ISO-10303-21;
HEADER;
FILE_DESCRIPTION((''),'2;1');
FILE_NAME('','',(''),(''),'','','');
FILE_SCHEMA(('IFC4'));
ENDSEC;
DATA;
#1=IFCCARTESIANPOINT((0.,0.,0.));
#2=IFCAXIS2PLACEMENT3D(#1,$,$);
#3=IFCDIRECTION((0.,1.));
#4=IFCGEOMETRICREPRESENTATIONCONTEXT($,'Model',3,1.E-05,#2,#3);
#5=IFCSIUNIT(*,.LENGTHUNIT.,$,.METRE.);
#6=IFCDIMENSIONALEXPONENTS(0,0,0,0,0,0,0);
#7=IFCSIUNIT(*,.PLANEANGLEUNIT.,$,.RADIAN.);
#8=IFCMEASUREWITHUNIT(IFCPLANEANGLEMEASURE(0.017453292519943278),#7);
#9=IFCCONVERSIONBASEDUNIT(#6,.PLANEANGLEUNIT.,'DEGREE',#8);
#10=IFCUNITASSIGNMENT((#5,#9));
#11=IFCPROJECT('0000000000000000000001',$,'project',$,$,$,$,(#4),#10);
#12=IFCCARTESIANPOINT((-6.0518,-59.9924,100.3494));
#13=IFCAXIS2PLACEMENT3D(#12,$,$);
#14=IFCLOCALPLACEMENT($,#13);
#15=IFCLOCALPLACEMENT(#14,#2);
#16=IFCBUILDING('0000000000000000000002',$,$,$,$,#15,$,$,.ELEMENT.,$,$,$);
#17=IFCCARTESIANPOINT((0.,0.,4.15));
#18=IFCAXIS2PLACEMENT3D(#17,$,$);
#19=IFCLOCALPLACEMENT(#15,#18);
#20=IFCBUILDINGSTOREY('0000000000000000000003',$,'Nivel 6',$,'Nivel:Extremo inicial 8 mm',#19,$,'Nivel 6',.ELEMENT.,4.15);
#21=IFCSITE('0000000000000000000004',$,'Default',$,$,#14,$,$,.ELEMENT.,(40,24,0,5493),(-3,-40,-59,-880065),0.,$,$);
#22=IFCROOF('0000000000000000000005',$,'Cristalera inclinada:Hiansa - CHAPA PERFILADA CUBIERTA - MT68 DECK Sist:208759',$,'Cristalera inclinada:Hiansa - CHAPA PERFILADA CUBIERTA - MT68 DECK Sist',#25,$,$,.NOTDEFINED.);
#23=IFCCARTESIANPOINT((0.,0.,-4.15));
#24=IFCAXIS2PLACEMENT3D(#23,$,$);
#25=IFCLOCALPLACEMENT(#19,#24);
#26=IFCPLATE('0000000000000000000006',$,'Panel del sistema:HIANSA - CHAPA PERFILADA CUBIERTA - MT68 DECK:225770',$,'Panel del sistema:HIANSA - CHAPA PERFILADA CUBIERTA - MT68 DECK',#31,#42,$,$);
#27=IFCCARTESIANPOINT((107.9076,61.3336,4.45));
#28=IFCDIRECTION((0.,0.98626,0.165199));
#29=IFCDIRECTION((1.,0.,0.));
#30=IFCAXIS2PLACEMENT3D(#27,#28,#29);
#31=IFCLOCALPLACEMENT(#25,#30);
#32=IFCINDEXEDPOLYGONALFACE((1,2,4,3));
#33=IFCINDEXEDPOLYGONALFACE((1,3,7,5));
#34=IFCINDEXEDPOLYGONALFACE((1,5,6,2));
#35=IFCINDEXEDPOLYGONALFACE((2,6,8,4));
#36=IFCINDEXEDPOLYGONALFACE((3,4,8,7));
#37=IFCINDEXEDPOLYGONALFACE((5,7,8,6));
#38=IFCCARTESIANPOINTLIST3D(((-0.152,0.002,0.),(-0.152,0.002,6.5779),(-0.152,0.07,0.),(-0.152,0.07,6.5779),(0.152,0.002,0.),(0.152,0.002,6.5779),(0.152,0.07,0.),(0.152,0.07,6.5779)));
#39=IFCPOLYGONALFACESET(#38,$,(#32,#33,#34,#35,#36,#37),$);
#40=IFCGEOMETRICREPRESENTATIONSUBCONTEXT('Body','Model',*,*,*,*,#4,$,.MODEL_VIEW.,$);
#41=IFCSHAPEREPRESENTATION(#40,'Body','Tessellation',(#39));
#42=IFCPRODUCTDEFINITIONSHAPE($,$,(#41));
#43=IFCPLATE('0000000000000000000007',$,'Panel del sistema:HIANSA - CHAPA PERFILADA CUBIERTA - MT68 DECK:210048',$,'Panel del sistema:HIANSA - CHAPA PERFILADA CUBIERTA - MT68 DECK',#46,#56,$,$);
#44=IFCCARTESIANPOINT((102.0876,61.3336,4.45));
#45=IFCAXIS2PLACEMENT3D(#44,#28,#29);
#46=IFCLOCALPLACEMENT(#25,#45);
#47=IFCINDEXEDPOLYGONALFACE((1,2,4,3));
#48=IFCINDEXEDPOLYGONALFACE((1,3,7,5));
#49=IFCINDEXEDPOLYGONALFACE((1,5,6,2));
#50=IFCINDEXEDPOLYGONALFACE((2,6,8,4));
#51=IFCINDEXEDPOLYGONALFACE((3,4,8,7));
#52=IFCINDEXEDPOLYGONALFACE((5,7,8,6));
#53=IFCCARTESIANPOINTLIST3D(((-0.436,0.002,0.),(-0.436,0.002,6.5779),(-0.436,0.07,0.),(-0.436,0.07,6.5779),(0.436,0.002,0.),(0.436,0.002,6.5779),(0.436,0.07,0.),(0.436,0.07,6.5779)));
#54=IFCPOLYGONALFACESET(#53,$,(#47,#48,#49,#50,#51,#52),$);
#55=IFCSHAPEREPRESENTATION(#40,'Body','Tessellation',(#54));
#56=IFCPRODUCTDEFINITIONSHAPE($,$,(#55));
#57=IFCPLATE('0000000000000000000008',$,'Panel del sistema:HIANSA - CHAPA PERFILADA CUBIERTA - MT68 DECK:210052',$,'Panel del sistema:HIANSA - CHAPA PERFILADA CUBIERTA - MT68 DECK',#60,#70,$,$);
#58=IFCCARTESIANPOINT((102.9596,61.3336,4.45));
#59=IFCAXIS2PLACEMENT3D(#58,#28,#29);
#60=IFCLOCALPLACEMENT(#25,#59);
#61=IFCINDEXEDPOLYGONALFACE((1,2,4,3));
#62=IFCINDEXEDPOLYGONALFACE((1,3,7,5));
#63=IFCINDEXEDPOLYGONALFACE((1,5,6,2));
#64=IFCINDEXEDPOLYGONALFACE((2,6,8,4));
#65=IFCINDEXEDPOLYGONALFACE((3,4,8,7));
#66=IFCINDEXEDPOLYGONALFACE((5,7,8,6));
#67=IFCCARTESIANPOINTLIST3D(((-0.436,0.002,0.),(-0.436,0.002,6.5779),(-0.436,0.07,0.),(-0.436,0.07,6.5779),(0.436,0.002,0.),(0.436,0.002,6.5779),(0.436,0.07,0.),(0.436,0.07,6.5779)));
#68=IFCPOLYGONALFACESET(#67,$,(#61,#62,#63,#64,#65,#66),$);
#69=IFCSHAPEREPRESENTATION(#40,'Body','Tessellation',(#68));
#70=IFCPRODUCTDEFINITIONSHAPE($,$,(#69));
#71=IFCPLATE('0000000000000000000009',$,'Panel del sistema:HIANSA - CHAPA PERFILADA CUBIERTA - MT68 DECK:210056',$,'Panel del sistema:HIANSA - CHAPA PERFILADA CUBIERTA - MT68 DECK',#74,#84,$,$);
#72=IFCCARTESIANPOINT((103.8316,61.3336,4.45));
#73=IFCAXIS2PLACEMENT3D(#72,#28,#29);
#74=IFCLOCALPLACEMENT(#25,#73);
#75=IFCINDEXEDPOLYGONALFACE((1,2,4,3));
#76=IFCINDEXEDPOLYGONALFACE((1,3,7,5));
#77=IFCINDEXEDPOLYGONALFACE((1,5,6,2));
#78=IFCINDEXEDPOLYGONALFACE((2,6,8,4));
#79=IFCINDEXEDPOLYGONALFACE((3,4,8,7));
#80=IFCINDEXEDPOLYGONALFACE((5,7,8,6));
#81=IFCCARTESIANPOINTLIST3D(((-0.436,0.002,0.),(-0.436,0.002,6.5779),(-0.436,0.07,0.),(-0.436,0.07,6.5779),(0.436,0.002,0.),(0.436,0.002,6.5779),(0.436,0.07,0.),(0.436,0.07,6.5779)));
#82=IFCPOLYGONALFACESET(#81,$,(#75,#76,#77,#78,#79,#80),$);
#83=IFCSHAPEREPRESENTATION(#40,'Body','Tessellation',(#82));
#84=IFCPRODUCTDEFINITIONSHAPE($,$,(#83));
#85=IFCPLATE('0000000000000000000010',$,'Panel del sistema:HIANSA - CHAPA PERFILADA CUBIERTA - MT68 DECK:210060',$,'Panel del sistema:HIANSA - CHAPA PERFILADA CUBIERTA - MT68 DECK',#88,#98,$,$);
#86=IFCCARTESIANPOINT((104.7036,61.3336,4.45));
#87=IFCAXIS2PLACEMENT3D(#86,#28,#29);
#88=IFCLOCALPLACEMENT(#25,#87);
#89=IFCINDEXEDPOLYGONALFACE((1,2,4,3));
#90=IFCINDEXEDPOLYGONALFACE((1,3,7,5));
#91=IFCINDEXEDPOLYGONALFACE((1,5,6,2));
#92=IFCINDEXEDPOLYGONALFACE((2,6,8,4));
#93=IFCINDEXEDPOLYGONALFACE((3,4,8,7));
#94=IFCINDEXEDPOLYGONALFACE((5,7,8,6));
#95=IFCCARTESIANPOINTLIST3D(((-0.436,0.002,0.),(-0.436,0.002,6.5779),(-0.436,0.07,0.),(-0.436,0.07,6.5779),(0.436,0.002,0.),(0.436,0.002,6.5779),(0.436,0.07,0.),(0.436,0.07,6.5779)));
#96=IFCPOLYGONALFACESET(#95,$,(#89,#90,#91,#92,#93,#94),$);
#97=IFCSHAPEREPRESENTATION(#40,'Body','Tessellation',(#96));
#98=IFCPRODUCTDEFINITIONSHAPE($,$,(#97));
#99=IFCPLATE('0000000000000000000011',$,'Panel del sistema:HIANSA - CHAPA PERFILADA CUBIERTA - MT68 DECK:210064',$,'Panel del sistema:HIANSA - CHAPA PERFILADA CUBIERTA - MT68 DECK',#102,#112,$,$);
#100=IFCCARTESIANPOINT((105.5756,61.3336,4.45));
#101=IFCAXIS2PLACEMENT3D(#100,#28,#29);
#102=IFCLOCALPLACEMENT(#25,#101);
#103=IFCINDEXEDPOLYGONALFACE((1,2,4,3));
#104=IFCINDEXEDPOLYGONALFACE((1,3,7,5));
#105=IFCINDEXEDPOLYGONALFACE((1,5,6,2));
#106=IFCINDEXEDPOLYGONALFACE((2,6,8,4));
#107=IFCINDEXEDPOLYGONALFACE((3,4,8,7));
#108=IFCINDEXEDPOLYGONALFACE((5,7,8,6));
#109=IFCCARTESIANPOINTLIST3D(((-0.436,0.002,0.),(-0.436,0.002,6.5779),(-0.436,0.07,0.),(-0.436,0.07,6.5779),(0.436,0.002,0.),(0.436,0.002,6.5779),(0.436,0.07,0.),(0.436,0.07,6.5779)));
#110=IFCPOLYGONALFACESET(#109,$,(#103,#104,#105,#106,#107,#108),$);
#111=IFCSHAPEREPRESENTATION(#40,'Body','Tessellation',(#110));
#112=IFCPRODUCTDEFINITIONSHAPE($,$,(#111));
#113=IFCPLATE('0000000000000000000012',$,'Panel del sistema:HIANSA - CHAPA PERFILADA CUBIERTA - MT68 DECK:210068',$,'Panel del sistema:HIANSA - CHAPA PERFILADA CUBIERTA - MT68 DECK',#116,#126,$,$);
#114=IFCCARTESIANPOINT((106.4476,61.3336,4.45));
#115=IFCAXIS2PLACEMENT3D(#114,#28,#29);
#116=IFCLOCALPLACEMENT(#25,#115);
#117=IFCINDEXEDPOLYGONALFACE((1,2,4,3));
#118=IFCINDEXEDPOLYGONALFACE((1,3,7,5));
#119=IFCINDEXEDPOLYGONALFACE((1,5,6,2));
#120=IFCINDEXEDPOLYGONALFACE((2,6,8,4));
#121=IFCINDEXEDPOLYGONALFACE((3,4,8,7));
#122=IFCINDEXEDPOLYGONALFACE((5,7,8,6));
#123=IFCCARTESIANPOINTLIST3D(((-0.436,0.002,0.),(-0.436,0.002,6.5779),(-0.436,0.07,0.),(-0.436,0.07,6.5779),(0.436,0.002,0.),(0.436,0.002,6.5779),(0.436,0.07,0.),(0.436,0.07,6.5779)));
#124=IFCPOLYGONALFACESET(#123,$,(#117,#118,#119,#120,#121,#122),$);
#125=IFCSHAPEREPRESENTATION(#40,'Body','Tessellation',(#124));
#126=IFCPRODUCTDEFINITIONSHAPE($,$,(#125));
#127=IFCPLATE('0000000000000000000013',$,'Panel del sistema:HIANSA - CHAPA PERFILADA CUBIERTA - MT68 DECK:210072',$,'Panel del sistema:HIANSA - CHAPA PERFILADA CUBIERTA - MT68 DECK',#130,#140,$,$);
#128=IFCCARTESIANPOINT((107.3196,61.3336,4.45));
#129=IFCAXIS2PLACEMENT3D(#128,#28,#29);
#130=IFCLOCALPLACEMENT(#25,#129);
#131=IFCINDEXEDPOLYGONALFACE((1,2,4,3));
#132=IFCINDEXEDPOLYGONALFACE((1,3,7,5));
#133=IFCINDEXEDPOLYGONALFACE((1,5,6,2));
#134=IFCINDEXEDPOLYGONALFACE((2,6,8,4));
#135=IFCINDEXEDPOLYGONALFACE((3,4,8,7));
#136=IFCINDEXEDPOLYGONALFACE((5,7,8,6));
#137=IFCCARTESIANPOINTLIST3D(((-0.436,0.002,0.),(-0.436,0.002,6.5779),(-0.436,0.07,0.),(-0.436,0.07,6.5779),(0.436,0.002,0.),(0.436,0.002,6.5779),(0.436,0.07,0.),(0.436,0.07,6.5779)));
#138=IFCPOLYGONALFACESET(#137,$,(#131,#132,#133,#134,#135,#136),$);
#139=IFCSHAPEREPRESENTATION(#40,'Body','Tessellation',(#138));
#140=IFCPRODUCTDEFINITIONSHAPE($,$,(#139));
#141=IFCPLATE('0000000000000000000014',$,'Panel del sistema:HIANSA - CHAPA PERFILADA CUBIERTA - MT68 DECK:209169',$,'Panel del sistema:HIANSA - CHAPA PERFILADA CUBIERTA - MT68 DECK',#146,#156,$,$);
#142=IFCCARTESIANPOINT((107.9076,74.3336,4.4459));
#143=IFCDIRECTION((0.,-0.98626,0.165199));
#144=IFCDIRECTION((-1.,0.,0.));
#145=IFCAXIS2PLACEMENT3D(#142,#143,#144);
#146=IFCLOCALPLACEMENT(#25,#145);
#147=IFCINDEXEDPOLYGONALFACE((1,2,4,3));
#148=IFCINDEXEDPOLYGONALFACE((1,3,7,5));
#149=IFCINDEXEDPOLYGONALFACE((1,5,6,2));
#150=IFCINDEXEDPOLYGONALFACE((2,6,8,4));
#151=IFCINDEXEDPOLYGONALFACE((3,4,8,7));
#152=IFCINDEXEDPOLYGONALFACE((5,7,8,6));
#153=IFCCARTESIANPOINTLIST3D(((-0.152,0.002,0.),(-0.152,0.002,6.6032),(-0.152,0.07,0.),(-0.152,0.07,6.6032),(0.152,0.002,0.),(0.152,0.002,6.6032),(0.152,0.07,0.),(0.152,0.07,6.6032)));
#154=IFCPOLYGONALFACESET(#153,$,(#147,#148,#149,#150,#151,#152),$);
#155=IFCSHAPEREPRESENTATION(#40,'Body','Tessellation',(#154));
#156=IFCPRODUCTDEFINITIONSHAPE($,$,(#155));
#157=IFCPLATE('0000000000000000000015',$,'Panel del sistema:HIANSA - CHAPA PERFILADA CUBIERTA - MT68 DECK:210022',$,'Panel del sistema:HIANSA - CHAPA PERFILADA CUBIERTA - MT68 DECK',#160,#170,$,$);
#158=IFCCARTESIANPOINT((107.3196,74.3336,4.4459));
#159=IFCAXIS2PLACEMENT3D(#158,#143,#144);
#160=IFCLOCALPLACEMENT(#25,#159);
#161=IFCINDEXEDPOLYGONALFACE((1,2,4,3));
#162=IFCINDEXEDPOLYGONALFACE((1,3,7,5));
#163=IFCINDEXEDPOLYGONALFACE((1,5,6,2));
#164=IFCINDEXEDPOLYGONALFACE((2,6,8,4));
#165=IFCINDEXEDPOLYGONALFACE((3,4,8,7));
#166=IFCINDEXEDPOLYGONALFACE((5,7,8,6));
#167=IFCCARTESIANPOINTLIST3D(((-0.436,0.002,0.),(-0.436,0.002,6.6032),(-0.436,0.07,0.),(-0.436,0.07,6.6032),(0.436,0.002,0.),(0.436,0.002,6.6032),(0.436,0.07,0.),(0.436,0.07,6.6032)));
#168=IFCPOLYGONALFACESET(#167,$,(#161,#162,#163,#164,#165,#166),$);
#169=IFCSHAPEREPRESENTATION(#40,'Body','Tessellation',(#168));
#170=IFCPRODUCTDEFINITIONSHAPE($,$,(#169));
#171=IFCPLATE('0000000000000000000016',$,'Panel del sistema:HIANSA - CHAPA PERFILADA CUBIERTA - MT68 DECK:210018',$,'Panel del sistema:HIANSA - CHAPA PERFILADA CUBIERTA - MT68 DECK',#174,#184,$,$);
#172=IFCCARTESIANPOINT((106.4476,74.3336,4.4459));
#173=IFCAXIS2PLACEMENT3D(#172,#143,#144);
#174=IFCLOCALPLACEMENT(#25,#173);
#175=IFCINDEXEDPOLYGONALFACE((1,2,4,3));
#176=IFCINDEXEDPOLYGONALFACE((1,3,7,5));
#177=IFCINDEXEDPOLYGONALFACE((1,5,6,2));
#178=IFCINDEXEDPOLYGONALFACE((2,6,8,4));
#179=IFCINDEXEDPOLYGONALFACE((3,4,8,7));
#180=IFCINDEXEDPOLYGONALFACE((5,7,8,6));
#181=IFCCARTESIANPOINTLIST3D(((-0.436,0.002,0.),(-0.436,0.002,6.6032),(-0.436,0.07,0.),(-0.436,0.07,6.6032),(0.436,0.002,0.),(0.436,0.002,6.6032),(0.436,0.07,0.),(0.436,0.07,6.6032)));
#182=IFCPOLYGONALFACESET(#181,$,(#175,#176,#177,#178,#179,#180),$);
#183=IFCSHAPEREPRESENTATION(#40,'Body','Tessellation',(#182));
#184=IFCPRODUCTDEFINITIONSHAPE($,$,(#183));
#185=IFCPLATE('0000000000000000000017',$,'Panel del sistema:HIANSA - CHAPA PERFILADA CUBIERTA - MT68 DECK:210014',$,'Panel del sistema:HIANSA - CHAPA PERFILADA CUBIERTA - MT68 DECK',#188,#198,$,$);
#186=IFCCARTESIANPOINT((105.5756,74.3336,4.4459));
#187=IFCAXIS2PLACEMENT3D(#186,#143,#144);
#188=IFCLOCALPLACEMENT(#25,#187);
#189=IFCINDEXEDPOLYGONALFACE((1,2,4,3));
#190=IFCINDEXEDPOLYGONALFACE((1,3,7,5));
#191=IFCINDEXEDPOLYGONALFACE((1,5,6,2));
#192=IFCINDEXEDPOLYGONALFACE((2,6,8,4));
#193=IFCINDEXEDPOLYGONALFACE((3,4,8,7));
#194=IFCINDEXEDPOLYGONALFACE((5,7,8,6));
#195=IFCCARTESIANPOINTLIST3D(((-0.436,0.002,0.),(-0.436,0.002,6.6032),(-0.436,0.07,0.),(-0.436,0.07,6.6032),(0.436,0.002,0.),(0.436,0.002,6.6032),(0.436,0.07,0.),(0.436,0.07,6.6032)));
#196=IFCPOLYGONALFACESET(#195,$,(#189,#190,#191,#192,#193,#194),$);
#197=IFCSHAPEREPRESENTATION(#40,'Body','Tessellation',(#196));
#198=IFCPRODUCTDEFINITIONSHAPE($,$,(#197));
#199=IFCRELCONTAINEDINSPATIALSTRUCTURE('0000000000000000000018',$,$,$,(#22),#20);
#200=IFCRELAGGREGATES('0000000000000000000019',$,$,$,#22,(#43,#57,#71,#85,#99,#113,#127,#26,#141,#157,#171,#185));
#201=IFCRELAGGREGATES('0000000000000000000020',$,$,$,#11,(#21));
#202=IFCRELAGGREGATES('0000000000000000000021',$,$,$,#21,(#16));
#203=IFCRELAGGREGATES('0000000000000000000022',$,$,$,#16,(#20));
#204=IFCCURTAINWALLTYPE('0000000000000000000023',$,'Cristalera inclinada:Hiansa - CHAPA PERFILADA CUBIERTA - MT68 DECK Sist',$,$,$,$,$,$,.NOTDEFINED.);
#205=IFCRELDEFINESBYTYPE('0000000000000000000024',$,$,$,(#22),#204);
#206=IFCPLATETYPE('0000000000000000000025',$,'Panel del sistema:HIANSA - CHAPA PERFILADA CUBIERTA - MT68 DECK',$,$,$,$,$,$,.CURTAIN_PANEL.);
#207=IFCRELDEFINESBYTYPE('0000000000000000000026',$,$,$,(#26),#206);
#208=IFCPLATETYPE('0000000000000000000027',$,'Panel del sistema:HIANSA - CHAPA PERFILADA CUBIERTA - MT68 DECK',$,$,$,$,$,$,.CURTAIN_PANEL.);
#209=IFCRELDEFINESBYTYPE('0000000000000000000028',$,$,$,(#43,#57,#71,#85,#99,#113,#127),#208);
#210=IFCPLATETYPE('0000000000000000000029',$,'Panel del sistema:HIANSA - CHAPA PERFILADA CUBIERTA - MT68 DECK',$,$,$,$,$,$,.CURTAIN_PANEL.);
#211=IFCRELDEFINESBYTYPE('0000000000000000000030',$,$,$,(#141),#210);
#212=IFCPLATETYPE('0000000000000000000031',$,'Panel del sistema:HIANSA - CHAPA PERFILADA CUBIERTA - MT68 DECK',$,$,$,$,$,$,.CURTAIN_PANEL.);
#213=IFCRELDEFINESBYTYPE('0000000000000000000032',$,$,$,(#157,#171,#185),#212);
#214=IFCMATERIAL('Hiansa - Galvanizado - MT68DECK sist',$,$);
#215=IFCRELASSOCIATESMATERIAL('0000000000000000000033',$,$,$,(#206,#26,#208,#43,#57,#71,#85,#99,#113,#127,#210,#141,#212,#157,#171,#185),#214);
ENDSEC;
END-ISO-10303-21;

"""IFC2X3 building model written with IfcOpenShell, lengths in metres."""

from ifc_helpers import new_model, entity, si_unit, converted_unit, direction, frame, origin, origin_2d_with_axis, place, context, subcontext, project, spatial, rectangle, extrude, source, transform, mapped, material, type_object, type_shapes, element, aggregate, save


model = new_model("IFC2X3")

# Units and contexts
model_context = context("Model", 3, precision=1e-05, world=origin(), true_north=direction((0.0, 1.0)))
body_context = subcontext(model_context, "Body", "Model", "MODEL_VIEW")
ifc_project = project(units=[si_unit("LENGTHUNIT", "METRE"), converted_unit("PLANEANGLEUNIT", "DEGREE", entity("IfcPlaneAngleMeasure", 0.017453292519943278), si_unit("PLANEANGLEUNIT", "RADIAN"), dimensions=[0, 0, 0, 0, 0, 0, 0])], contexts=[model_context])

# Site, building, storey
site_placement = place(None, frame((-6.0518, -59.9924, 100.3494)))
site = spatial("IfcSite", under=ifc_project, at=site_placement, Name="Default", CompositionType="ELEMENT", RefLatitude=(40, 24, 0, 5493), RefLongitude=(-3, -40, -59, -880065), RefElevation=0.0)
building_placement = place(site_placement, origin())
building = spatial("IfcBuilding", under=site, at=building_placement, CompositionType="ELEMENT")
storey_placement = place(building_placement, frame((0.0, 0.0, 4.15)))
storey = spatial("IfcBuildingStorey", under=building, at=storey_placement, Name="Nivel 6", ObjectType="Nivel:Extremo inicial 8 mm", LongName="Nivel 6", CompositionType="ELEMENT", Elevation=4.15)

# Roof, plates
curtain_wall_type = type_object("IfcCurtainWallType", Name="Cristalera inclinada:Hiansa - CHAPA PERFILADA CUBIERTA - MT68 DECK Sist", PredefinedType="NOTDEFINED")
roof_placement = place(storey_placement, frame((0.0, 0.0, -4.15)))
roof = element("IfcRoof", 1, at=roof_placement, inside=storey, type_object=curtain_wall_type, Name="Cristalera inclinada:Hiansa - CHAPA PERFILADA CUBIERTA - MT68 DECK Sist:208759", ObjectType="Cristalera inclinada:Hiansa - CHAPA PERFILADA CUBIERTA - MT68 DECK Sist", ShapeType="NOTDEFINED")
ifc_material_1 = material(Name="Hiansa - Galvanizado - MT68DECK sist")
plate_type_1 = type_object("IfcPlateType", Name="Panel del sistema:HIANSA - CHAPA PERFILADA CUBIERTA - MT68 DECK", PredefinedType="CURTAIN_PANEL", material=ifc_material_1)
shared_shape_1 = source(origin(), body_context, "Body", "SweptSolid", [
    extrude(rectangle(XDim=0.068, YDim=0.304, at=origin_2d_with_axis()), frame((0.0, 0.036, 0.0), z_axis=(0.0, 0.0, 1.0), x_axis=(0.0, 1.0, 0.0)), (0.0, 0.0, 1.0), 6.5779),
])
type_shapes(plate_type_1, [shared_shape_1])
plate_1_placement = place(roof_placement, frame((107.9076, 61.3336, 4.45), z_axis=(0.0, 0.98626, 0.165199), x_axis=(1.0, 0.0, 0.0)))
plate_1 = element("IfcPlate", 2, at=plate_1_placement, type_object=plate_type_1, material=ifc_material_1, Name="Panel del sistema:HIANSA - CHAPA PERFILADA CUBIERTA - MT68 DECK:225770", ObjectType="Panel del sistema:HIANSA - CHAPA PERFILADA CUBIERTA - MT68 DECK", context=body_context, shape_type="MappedRepresentation", body=[
    mapped(shared_shape_1, transform((0.0, 0.0, 0.0), scale=1.0)),
])
plate_type_2 = type_object("IfcPlateType", Name="Panel del sistema:HIANSA - CHAPA PERFILADA CUBIERTA - MT68 DECK", PredefinedType="CURTAIN_PANEL", material=ifc_material_1)
shared_shape_2 = source(origin(), body_context, "Body", "SweptSolid", [
    extrude(rectangle(XDim=0.068, YDim=0.872, at=origin_2d_with_axis()), frame((0.0, 0.036, 0.0), z_axis=(0.0, 0.0, 1.0), x_axis=(0.0, 1.0, 0.0)), (0.0, 0.0, 1.0), 6.5779),
])
type_shapes(plate_type_2, [shared_shape_2])
plate_2_placement = place(roof_placement, frame((102.0876, 61.3336, 4.45), z_axis=(0.0, 0.98626, 0.165199), x_axis=(1.0, 0.0, 0.0)))
plate_2 = element("IfcPlate", 3, at=plate_2_placement, type_object=plate_type_2, material=ifc_material_1, Name="Panel del sistema:HIANSA - CHAPA PERFILADA CUBIERTA - MT68 DECK:210048", ObjectType="Panel del sistema:HIANSA - CHAPA PERFILADA CUBIERTA - MT68 DECK", context=body_context, shape_type="MappedRepresentation", body=[
    mapped(shared_shape_2, transform((0.0, 0.0, 0.0), scale=1.0)),
])
plate_3_placement = place(roof_placement, frame((102.9596, 61.3336, 4.45), z_axis=(0.0, 0.98626, 0.165199), x_axis=(1.0, 0.0, 0.0)))
plate_3 = element("IfcPlate", 4, at=plate_3_placement, type_object=plate_type_2, material=ifc_material_1, Name="Panel del sistema:HIANSA - CHAPA PERFILADA CUBIERTA - MT68 DECK:210052", ObjectType="Panel del sistema:HIANSA - CHAPA PERFILADA CUBIERTA - MT68 DECK", context=body_context, shape_type="MappedRepresentation", body=[
    mapped(shared_shape_2, transform((0.0, 0.0, 0.0), scale=1.0)),
])
plate_4_placement = place(roof_placement, frame((103.8316, 61.3336, 4.45), z_axis=(0.0, 0.98626, 0.165199), x_axis=(1.0, 0.0, 0.0)))
plate_4 = element("IfcPlate", 5, at=plate_4_placement, type_object=plate_type_2, material=ifc_material_1, Name="Panel del sistema:HIANSA - CHAPA PERFILADA CUBIERTA - MT68 DECK:210056", ObjectType="Panel del sistema:HIANSA - CHAPA PERFILADA CUBIERTA - MT68 DECK", context=body_context, shape_type="MappedRepresentation", body=[
    mapped(shared_shape_2, transform((0.0, 0.0, 0.0), scale=1.0)),
])
plate_5_placement = place(roof_placement, frame((104.7036, 61.3336, 4.45), z_axis=(0.0, 0.98626, 0.165199), x_axis=(1.0, 0.0, 0.0)))
plate_5 = element("IfcPlate", 6, at=plate_5_placement, type_object=plate_type_2, material=ifc_material_1, Name="Panel del sistema:HIANSA - CHAPA PERFILADA CUBIERTA - MT68 DECK:210060", ObjectType="Panel del sistema:HIANSA - CHAPA PERFILADA CUBIERTA - MT68 DECK", context=body_context, shape_type="MappedRepresentation", body=[
    mapped(shared_shape_2, transform((0.0, 0.0, 0.0), scale=1.0)),
])
plate_6_placement = place(roof_placement, frame((105.5756, 61.3336, 4.45), z_axis=(0.0, 0.98626, 0.165199), x_axis=(1.0, 0.0, 0.0)))
plate_6 = element("IfcPlate", 7, at=plate_6_placement, type_object=plate_type_2, material=ifc_material_1, Name="Panel del sistema:HIANSA - CHAPA PERFILADA CUBIERTA - MT68 DECK:210064", ObjectType="Panel del sistema:HIANSA - CHAPA PERFILADA CUBIERTA - MT68 DECK", context=body_context, shape_type="MappedRepresentation", body=[
    mapped(shared_shape_2, transform((0.0, 0.0, 0.0), scale=1.0)),
])
plate_7_placement = place(roof_placement, frame((106.4476, 61.3336, 4.45), z_axis=(0.0, 0.98626, 0.165199), x_axis=(1.0, 0.0, 0.0)))
plate_7 = element("IfcPlate", 8, at=plate_7_placement, type_object=plate_type_2, material=ifc_material_1, Name="Panel del sistema:HIANSA - CHAPA PERFILADA CUBIERTA - MT68 DECK:210068", ObjectType="Panel del sistema:HIANSA - CHAPA PERFILADA CUBIERTA - MT68 DECK", context=body_context, shape_type="MappedRepresentation", body=[
    mapped(shared_shape_2, transform((0.0, 0.0, 0.0), scale=1.0)),
])
plate_8_placement = place(roof_placement, frame((107.3196, 61.3336, 4.45), z_axis=(0.0, 0.98626, 0.165199), x_axis=(1.0, 0.0, 0.0)))
plate_8 = element("IfcPlate", 9, at=plate_8_placement, type_object=plate_type_2, material=ifc_material_1, Name="Panel del sistema:HIANSA - CHAPA PERFILADA CUBIERTA - MT68 DECK:210072", ObjectType="Panel del sistema:HIANSA - CHAPA PERFILADA CUBIERTA - MT68 DECK", context=body_context, shape_type="MappedRepresentation", body=[
    mapped(shared_shape_2, transform((0.0, 0.0, 0.0), scale=1.0)),
])
plate_type_3 = type_object("IfcPlateType", Name="Panel del sistema:HIANSA - CHAPA PERFILADA CUBIERTA - MT68 DECK", PredefinedType="CURTAIN_PANEL", material=ifc_material_1)
shared_shape_3 = source(origin(), body_context, "Body", "SweptSolid", [
    extrude(rectangle(XDim=0.068, YDim=0.304, at=origin_2d_with_axis()), frame((0.0, 0.036, 0.0), z_axis=(0.0, 0.0, 1.0), x_axis=(0.0, 1.0, 0.0)), (0.0, 0.0, 1.0), 6.6032),
])
type_shapes(plate_type_3, [shared_shape_3])
plate_9_placement = place(roof_placement, frame((107.9076, 74.3336, 4.4459), z_axis=(0.0, -0.98626, 0.165199), x_axis=(-1.0, 0.0, 0.0)))
plate_9 = element("IfcPlate", 10, at=plate_9_placement, type_object=plate_type_3, material=ifc_material_1, Name="Panel del sistema:HIANSA - CHAPA PERFILADA CUBIERTA - MT68 DECK:209169", ObjectType="Panel del sistema:HIANSA - CHAPA PERFILADA CUBIERTA - MT68 DECK", context=body_context, shape_type="MappedRepresentation", body=[
    mapped(shared_shape_3, transform((0.0, 0.0, 0.0), scale=1.0)),
])
plate_type_4 = type_object("IfcPlateType", Name="Panel del sistema:HIANSA - CHAPA PERFILADA CUBIERTA - MT68 DECK", PredefinedType="CURTAIN_PANEL", material=ifc_material_1)
shared_shape_4 = source(origin(), body_context, "Body", "SweptSolid", [
    extrude(rectangle(XDim=0.068, YDim=0.872, at=origin_2d_with_axis()), frame((0.0, 0.036, 0.0), z_axis=(0.0, 0.0, 1.0), x_axis=(0.0, 1.0, 0.0)), (0.0, 0.0, 1.0), 6.6032),
])
type_shapes(plate_type_4, [shared_shape_4])
plate_10_placement = place(roof_placement, frame((107.3196, 74.3336, 4.4459), z_axis=(0.0, -0.98626, 0.165199), x_axis=(-1.0, 0.0, 0.0)))
plate_10 = element("IfcPlate", 11, at=plate_10_placement, type_object=plate_type_4, material=ifc_material_1, Name="Panel del sistema:HIANSA - CHAPA PERFILADA CUBIERTA - MT68 DECK:210022", ObjectType="Panel del sistema:HIANSA - CHAPA PERFILADA CUBIERTA - MT68 DECK", context=body_context, shape_type="MappedRepresentation", body=[
    mapped(shared_shape_4, transform((0.0, 0.0, 0.0), scale=1.0)),
])
plate_11_placement = place(roof_placement, frame((106.4476, 74.3336, 4.4459), z_axis=(0.0, -0.98626, 0.165199), x_axis=(-1.0, 0.0, 0.0)))
plate_11 = element("IfcPlate", 12, at=plate_11_placement, type_object=plate_type_4, material=ifc_material_1, Name="Panel del sistema:HIANSA - CHAPA PERFILADA CUBIERTA - MT68 DECK:210018", ObjectType="Panel del sistema:HIANSA - CHAPA PERFILADA CUBIERTA - MT68 DECK", context=body_context, shape_type="MappedRepresentation", body=[
    mapped(shared_shape_4, transform((0.0, 0.0, 0.0), scale=1.0)),
])
plate_12_placement = place(roof_placement, frame((105.5756, 74.3336, 4.4459), z_axis=(0.0, -0.98626, 0.165199), x_axis=(-1.0, 0.0, 0.0)))
plate_12 = element("IfcPlate", 13, at=plate_12_placement, type_object=plate_type_4, material=ifc_material_1, Name="Panel del sistema:HIANSA - CHAPA PERFILADA CUBIERTA - MT68 DECK:210014", ObjectType="Panel del sistema:HIANSA - CHAPA PERFILADA CUBIERTA - MT68 DECK", context=body_context, shape_type="MappedRepresentation", body=[
    mapped(shared_shape_4, transform((0.0, 0.0, 0.0), scale=1.0)),
])
aggregate(roof, [plate_2, plate_3, plate_4, plate_5, plate_6, plate_7, plate_8, plate_1, plate_9, plate_10, plate_11, plate_12])

save(model, "model.ifc")
